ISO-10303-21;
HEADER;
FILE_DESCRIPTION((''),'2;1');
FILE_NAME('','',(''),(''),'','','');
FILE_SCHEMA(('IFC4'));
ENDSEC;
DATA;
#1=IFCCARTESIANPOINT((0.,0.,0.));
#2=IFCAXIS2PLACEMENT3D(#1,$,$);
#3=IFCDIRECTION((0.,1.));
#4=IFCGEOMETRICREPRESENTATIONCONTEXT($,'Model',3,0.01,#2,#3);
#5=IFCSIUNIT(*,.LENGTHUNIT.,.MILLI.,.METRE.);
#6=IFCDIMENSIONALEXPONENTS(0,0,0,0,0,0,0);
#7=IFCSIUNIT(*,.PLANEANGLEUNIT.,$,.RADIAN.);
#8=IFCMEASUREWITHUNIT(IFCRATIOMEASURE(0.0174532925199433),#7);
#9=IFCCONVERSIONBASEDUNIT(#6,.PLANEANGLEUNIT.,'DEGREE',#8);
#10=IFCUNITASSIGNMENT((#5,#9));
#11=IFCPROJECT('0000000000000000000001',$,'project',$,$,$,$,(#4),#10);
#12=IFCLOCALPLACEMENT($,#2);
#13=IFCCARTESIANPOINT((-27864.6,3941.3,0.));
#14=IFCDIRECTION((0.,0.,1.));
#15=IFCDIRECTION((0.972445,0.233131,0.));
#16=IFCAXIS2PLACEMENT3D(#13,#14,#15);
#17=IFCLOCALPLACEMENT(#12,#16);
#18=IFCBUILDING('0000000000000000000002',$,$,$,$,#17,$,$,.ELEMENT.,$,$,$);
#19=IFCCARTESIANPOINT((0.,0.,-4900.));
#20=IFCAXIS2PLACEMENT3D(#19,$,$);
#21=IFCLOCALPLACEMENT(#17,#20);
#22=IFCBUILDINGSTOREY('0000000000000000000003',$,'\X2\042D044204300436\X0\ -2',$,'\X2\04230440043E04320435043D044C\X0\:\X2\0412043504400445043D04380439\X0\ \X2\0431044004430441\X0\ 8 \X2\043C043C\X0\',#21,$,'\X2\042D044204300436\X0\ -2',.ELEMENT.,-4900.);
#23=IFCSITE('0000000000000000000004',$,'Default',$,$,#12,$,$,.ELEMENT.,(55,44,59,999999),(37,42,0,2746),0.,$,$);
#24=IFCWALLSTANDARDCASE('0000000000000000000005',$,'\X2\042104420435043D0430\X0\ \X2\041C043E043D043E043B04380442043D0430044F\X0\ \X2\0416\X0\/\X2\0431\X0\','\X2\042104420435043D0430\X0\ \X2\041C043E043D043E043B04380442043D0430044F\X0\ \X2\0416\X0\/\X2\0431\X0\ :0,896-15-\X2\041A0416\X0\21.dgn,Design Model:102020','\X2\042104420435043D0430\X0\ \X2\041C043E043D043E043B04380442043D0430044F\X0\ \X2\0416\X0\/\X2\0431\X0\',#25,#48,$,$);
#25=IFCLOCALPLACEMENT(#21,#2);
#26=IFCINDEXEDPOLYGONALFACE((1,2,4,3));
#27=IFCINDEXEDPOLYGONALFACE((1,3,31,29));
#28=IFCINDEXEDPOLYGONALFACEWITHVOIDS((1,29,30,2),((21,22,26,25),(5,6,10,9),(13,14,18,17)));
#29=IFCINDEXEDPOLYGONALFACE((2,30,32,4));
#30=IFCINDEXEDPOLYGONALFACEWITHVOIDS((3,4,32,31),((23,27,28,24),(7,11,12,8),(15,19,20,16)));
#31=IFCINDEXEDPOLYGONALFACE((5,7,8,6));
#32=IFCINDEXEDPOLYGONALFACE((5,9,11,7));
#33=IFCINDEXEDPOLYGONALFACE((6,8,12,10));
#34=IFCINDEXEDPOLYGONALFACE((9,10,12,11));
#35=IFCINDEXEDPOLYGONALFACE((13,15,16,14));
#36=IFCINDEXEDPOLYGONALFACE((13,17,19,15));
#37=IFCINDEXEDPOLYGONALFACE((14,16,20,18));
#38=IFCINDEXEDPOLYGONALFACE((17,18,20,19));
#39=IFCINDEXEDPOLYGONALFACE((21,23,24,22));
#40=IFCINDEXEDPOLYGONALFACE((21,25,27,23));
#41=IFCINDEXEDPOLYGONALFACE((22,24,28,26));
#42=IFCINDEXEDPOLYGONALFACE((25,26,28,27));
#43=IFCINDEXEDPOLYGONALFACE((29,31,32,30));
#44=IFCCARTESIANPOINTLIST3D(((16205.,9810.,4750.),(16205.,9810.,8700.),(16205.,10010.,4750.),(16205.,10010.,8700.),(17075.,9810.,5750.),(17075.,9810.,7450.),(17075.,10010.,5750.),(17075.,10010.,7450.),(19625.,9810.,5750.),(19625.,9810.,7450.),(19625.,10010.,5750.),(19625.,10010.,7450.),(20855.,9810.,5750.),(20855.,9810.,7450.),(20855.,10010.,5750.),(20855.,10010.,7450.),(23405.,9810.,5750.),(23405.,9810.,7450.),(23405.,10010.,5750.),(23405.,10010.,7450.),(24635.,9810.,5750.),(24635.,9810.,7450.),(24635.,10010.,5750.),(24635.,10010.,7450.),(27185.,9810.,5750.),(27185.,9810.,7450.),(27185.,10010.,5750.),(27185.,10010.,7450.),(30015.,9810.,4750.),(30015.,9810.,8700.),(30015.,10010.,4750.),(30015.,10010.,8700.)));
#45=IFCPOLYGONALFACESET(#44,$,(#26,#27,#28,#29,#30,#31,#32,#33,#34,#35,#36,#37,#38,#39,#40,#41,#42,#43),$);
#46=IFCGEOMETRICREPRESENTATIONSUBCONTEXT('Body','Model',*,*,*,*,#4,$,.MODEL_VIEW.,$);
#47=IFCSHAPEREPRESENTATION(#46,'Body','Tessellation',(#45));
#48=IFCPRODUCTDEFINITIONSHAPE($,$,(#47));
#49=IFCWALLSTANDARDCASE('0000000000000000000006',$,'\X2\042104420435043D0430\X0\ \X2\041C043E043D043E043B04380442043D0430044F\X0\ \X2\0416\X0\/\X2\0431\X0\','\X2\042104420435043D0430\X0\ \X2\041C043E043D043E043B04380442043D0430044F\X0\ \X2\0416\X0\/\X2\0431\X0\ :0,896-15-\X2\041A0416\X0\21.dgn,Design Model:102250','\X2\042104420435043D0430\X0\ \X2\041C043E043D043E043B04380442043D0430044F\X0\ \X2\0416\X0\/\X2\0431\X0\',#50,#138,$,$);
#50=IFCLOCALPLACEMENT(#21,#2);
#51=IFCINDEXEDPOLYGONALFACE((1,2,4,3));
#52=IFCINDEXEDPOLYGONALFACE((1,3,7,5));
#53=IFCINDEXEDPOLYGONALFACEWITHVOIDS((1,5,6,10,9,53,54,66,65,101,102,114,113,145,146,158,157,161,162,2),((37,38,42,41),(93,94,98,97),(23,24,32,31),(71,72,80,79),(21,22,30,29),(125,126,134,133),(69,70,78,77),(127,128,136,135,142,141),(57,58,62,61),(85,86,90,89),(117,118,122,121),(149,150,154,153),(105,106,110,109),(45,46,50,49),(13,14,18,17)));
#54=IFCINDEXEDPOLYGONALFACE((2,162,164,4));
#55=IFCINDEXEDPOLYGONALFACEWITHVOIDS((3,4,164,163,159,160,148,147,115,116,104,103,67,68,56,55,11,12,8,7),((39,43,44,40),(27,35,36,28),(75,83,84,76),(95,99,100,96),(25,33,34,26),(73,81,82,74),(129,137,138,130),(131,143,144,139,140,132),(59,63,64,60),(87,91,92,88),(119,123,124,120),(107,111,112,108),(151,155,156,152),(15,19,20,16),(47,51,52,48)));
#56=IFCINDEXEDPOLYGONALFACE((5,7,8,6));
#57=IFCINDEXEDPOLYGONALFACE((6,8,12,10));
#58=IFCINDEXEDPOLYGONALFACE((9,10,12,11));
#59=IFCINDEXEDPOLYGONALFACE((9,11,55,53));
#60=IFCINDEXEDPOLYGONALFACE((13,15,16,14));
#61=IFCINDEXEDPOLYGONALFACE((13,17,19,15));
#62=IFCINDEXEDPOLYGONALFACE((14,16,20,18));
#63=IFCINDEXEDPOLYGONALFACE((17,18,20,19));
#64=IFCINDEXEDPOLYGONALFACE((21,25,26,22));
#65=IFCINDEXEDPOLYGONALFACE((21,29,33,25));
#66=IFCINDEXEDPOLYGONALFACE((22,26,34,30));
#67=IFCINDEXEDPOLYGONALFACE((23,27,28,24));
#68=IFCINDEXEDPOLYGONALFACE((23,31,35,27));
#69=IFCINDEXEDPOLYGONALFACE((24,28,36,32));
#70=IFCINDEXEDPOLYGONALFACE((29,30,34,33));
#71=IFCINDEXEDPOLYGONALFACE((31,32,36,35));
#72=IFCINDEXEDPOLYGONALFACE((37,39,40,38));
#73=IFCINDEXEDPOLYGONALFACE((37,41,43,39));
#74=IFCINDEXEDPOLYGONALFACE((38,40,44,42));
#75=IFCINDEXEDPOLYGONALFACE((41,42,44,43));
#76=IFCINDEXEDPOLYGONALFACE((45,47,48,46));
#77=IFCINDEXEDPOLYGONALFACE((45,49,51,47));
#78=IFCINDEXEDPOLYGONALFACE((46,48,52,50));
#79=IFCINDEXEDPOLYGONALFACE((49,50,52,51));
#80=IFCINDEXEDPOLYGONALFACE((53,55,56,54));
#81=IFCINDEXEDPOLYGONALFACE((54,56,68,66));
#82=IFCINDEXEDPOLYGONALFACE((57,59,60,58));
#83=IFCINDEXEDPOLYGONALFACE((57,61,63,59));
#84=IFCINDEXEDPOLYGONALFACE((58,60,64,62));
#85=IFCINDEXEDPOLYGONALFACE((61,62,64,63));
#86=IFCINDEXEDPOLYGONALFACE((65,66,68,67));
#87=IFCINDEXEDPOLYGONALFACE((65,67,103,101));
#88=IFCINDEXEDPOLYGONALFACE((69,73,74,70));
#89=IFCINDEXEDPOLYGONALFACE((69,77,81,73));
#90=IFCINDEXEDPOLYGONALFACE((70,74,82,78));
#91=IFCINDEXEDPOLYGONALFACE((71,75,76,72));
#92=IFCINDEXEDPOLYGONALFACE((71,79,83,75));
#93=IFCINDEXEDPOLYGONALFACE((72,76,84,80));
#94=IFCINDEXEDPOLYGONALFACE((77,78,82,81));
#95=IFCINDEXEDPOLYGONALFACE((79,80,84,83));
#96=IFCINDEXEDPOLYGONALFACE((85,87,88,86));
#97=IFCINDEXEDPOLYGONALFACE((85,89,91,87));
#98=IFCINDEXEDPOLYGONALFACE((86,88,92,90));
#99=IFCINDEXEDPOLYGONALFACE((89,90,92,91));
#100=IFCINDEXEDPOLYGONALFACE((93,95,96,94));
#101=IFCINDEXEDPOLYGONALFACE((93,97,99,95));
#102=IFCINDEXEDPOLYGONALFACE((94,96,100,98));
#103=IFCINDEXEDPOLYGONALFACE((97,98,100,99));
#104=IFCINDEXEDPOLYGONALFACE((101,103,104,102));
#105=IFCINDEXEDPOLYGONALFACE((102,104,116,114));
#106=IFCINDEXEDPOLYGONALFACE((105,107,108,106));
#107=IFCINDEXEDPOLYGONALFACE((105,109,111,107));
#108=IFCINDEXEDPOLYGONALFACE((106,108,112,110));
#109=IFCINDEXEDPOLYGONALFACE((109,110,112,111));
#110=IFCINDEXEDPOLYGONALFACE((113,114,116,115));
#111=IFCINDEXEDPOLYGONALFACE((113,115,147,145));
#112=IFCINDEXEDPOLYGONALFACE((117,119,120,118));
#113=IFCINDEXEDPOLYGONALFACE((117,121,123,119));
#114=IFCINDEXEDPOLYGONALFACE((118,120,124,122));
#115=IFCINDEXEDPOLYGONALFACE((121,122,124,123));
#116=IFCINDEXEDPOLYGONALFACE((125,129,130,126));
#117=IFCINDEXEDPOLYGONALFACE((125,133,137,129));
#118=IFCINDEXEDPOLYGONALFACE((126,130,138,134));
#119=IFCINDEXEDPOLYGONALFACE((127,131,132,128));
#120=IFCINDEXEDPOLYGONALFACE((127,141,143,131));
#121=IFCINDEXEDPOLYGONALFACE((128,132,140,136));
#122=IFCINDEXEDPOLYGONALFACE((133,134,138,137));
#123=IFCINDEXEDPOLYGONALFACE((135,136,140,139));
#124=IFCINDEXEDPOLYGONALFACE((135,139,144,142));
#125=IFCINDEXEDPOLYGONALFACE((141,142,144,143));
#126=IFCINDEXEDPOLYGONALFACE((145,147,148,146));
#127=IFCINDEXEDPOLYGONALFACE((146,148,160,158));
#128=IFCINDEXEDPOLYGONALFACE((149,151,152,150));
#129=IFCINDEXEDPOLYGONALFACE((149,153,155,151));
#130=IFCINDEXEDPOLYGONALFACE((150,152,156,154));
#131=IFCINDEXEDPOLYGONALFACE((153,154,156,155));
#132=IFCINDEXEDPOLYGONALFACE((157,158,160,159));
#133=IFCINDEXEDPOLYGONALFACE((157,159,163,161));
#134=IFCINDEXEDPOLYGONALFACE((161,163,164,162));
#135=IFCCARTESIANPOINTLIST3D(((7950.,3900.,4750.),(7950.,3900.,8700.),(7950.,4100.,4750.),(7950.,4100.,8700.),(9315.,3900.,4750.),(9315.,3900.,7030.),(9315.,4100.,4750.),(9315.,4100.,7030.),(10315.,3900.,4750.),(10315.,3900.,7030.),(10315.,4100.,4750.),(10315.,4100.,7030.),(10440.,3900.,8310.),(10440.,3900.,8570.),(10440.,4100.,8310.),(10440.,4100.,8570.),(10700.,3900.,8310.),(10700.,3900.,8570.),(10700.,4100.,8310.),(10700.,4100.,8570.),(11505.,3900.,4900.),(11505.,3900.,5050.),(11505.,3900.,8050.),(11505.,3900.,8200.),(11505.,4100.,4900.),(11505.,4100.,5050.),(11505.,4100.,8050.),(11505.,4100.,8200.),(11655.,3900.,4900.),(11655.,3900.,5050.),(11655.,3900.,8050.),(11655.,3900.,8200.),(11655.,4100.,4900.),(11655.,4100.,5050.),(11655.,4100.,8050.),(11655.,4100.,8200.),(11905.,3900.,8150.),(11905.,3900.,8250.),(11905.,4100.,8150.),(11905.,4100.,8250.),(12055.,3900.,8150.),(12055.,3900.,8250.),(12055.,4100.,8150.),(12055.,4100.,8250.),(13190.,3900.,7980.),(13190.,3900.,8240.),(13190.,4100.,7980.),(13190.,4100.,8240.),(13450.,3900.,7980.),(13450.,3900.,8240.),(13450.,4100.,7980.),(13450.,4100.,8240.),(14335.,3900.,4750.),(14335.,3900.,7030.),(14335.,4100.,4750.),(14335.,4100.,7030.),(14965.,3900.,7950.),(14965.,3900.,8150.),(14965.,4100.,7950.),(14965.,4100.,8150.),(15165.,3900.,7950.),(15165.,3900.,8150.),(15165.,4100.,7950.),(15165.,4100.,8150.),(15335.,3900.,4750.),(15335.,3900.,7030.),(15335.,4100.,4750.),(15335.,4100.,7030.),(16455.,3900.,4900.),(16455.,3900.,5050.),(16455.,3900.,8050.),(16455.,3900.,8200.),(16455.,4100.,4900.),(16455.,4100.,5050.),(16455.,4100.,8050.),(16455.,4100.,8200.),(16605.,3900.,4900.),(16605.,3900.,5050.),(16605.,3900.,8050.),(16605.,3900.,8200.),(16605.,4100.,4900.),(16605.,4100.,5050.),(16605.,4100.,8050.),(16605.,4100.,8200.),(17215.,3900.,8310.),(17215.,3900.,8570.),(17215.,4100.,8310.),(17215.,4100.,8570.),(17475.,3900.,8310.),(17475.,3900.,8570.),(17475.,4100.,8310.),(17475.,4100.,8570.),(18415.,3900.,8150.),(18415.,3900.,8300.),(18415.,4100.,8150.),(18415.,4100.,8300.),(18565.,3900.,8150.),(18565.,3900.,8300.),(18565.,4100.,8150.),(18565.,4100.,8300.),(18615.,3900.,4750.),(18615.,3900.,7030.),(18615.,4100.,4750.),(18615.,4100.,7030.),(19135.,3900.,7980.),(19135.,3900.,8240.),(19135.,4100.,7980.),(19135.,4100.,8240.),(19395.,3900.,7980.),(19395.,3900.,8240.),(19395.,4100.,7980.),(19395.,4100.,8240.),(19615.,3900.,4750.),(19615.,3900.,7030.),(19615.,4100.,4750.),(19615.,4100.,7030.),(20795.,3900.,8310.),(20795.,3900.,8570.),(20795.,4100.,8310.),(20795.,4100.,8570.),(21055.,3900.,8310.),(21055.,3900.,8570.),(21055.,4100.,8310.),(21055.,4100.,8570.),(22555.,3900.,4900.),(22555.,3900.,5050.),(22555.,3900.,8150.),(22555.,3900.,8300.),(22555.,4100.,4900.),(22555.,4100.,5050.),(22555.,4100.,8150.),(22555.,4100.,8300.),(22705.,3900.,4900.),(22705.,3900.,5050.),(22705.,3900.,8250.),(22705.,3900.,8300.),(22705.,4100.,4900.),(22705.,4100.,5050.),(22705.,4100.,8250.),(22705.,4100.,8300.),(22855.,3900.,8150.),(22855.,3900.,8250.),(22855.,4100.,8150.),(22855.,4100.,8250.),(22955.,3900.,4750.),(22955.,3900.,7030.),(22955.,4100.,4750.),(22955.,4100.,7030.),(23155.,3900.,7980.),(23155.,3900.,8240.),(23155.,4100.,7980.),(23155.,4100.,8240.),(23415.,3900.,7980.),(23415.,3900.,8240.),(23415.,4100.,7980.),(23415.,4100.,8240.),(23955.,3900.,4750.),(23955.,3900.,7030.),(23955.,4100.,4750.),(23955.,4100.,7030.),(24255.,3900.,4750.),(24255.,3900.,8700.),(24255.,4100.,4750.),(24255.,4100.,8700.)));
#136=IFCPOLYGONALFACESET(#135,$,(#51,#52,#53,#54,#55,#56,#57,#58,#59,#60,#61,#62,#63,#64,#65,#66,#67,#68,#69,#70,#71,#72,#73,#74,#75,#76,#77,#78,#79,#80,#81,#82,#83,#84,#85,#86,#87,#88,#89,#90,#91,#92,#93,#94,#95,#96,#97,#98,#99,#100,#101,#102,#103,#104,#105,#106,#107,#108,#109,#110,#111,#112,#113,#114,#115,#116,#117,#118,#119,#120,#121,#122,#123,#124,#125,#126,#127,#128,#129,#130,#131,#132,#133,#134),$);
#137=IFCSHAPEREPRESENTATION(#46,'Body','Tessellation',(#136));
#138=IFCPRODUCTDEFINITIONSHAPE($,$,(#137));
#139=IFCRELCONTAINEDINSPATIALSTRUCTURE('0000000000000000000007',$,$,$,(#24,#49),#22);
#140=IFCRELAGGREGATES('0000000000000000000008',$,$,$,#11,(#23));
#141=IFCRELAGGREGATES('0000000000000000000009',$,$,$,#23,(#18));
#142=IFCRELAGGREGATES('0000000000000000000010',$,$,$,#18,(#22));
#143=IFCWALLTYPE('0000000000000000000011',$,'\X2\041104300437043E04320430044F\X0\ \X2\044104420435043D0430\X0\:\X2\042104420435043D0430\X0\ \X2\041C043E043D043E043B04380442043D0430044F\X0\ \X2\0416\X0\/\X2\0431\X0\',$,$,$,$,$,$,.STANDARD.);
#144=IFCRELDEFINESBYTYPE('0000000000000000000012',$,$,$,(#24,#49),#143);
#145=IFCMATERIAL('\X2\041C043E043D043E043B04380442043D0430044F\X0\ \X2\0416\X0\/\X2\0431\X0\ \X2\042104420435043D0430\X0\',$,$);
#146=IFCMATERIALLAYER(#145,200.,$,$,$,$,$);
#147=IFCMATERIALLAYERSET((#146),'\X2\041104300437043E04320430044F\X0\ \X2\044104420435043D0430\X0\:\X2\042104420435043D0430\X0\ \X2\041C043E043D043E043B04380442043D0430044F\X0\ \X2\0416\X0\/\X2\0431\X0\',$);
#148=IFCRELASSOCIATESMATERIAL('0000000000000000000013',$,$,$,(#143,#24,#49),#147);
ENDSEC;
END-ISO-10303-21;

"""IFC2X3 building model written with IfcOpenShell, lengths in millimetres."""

from ifc_helpers import new_model, entity, si_unit, converted_unit, direction, frame, frame_2d, origin, origin_2d_with_axis, place, context, subcontext, project, spatial, polyline, rectangle, outline, extrude, material, layer, layer_set, layer_usage, type_object, element, save


model = new_model("IFC2X3")

# Units and contexts
model_context = context("Model", 3, precision=0.01, world=origin(), true_north=direction((0.0, 1.0)))
body_context = subcontext(model_context, "Body", "Model", "MODEL_VIEW")
ifc_project = project(units=[si_unit("LENGTHUNIT", "METRE", prefix="MILLI"), converted_unit("PLANEANGLEUNIT", "DEGREE", entity("IfcRatioMeasure", 0.0174532925199433), si_unit("PLANEANGLEUNIT", "RADIAN"), dimensions=[0, 0, 0, 0, 0, 0, 0])], contexts=[model_context])

# Site, building, storey
site_placement = place(None, origin())
site = spatial("IfcSite", under=ifc_project, at=site_placement, Name="Default", CompositionType="ELEMENT", RefLatitude=(55, 44, 59, 999999), RefLongitude=(37, 42, 0, 2746), RefElevation=0.0)
building_placement = place(site_placement, frame((-27864.6, 3941.3, 0.0), z_axis=(0.0, 0.0, 1.0), x_axis=(0.972445, 0.233131, 0.0)))
building = spatial("IfcBuilding", under=site, at=building_placement, CompositionType="ELEMENT")
storey_placement = place(building_placement, frame((0.0, 0.0, -4900.0)))
storey = spatial("IfcBuildingStorey", under=building, at=storey_placement, Name="Этаж -2", ObjectType="Уровень:Верхний брус 8 мм", LongName="Этаж -2", CompositionType="ELEMENT", Elevation=-4900.0)

# Walls, openings
ifc_material = material(Name="Монолитная Ж/б Стена")
ifc_layer_1 = layer(ifc_material, 200.0)
ifc_layer_set_1 = layer_set([ifc_layer_1], Name="Базовая стена:Стена Монолитная Ж/б")
ifc_layer_usage_1 = layer_usage(ifc_layer_set_1, "AXIS2", "NEGATIVE", 100.0)
wall_type_1 = type_object("IfcWallType", Name="Базовая стена:Стена Монолитная Ж/б", PredefinedType="STANDARD", material=ifc_layer_set_1)
wall_1_placement = place(storey_placement, frame((16205.0, 9910.0, 4750.0)))
wall_1 = element("IfcWallStandardCase", 1, at=wall_1_placement, inside=storey, type_object=wall_type_1, material=ifc_layer_usage_1, Name="Стена Монолитная Ж/б", Description="Стена Монолитная Ж/б :0,896-15-КЖ21.dgn,Design Model:102020", ObjectType="Стена Монолитная Ж/б", context=body_context, shape_type="SweptSolid", body=[
    extrude(rectangle(XDim=13810.0, YDim=200.0, at=frame_2d((6905.0, 0.0), x_axis=(-1.0, 0.0))), origin(), (0.0, 0.0, 1.0), 3950.0),
])
placement_1 = place(wall_1_placement, origin())
element("IfcOpeningElement", 2, at=placement_1, cuts=wall_1, ObjectType="Opening", context=body_context, shape_type="SweptSolid", body=[
    extrude(rectangle(XDim=1700.0, YDim=2550.0, at=origin_2d_with_axis()), frame((2145.0, -100.0, 1850.0), z_axis=(0.0, 1.0, 0.0), x_axis=(0.0, 0.0, -1.0)), (0.0, 0.0, 1.0), 200.0),
])
element("IfcOpeningElement", 3, at=placement_1, cuts=wall_1, ObjectType="Opening", context=body_context, shape_type="SweptSolid", body=[
    extrude(rectangle(XDim=1700.0, YDim=2550.0, at=origin_2d_with_axis()), frame((5925.0, -100.0, 1850.0), z_axis=(0.0, 1.0, 0.0), x_axis=(0.0, 0.0, -1.0)), (0.0, 0.0, 1.0), 200.0),
])
element("IfcOpeningElement", 4, at=placement_1, cuts=wall_1, ObjectType="Opening", context=body_context, shape_type="SweptSolid", body=[
    extrude(rectangle(XDim=1700.0, YDim=2550.0, at=origin_2d_with_axis()), frame((9705.0, -100.0, 1850.0), z_axis=(0.0, 1.0, 0.0), x_axis=(0.0, 0.0, -1.0)), (0.0, 0.0, 1.0), 200.0),
])
wall_2_placement = place(storey_placement, frame((24255.0, 4000.0, 4750.0), z_axis=(0.0, 0.0, 1.0), x_axis=(-1.0, 0.0, 0.0)))
wall_2 = element("IfcWallStandardCase", 5, at=wall_2_placement, inside=storey, type_object=wall_type_1, material=ifc_layer_usage_1, Name="Стена Монолитная Ж/б", Description="Стена Монолитная Ж/б :0,896-15-КЖ21.dgn,Design Model:102250", ObjectType="Стена Монолитная Ж/б", context=body_context, shape_type="SweptSolid", body=[
    extrude(rectangle(XDim=16305.0, YDim=200.0, at=frame_2d((8152.5, 0.0), x_axis=(-1.0, 0.0))), origin(), (0.0, 0.0, 1.0), 3950.0),
])
placement_2 = place(wall_2_placement, origin())
element("IfcOpeningElement", 6, at=placement_2, cuts=wall_2, ObjectType="Opening", context=body_context, shape_type="SweptSolid", body=[
    extrude(rectangle(XDim=2280.0, YDim=1000.0, at=origin_2d_with_axis()), frame((14440.0, -100.0, 1140.0), z_axis=(0.0, 1.0, 0.0), x_axis=(0.0, 0.0, -1.0)), (0.0, 0.0, 1.0), 200.0),
])
element("IfcOpeningElement", 7, at=placement_2, cuts=wall_2, ObjectType="Opening", context=body_context, shape_type="SweptSolid", body=[
    extrude(rectangle(XDim=2280.0, YDim=1000.0, at=origin_2d_with_axis()), frame((9420.0, -100.0, 1140.0), z_axis=(0.0, 1.0, 0.0), x_axis=(0.0, 0.0, -1.0)), (0.0, 0.0, 1.0), 200.0),
])
element("IfcOpeningElement", 8, at=placement_2, cuts=wall_2, ObjectType="Opening", context=body_context, shape_type="SweptSolid", body=[
    extrude(rectangle(XDim=2280.0, YDim=1000.0, at=origin_2d_with_axis()), frame((5140.0, -100.0, 1140.0), z_axis=(0.0, 1.0, 0.0), x_axis=(0.0, 0.0, -1.0)), (0.0, 0.0, 1.0), 200.0),
])
element("IfcOpeningElement", 9, at=placement_2, cuts=wall_2, ObjectType="Opening", context=body_context, shape_type="SweptSolid", body=[
    extrude(rectangle(XDim=2280.0, YDim=1000.0, at=origin_2d_with_axis()), frame((800.0, -100.0, 1140.0), z_axis=(0.0, 1.0, 0.0), x_axis=(0.0, 0.0, -1.0)), (0.0, 0.0, 1.0), 200.0),
])
element("IfcOpeningElement", 10, at=placement_2, cuts=wall_2, ObjectType="Opening", context=body_context, shape_type="SweptSolid", body=[
    extrude(rectangle(XDim=200.0, YDim=200.0, at=origin_2d_with_axis()), frame((9190.0, -100.0, 3300.0), z_axis=(0.0, 1.0, 0.0), x_axis=(0.0, 0.0, -1.0)), (0.0, 0.0, 1.0), 200.0),
])
element("IfcOpeningElement", 11, at=placement_2, cuts=wall_2, ObjectType="Opening", context=body_context, shape_type="SweptSolid", body=[
    extrude(rectangle(XDim=150.0, YDim=150.0, at=origin_2d_with_axis()), frame((7725.0, -100.0, 225.0), z_axis=(0.0, 1.0, 0.0), x_axis=(0.0, 0.0, -1.0)), (0.0, 0.0, 1.0), 200.0),
])
element("IfcOpeningElement", 12, at=placement_2, cuts=wall_2, ObjectType="Opening", context=body_context, shape_type="SweptSolid", body=[
    extrude(rectangle(XDim=150.0, YDim=150.0, at=origin_2d_with_axis()), frame((7725.0, -100.0, 3375.0), z_axis=(0.0, 1.0, 0.0), x_axis=(0.0, 0.0, -1.0)), (0.0, 0.0, 1.0), 200.0),
])
element("IfcOpeningElement", 13, at=placement_2, cuts=wall_2, ObjectType="Opening", context=body_context, shape_type="SweptSolid", body=[
    extrude(rectangle(XDim=260.0, YDim=260.0, at=origin_2d_with_axis()), frame((6910.0, -100.0, 3690.0), z_axis=(0.0, 1.0, 0.0), x_axis=(0.0, 0.0, -1.0)), (0.0, 0.0, 1.0), 200.0),
])
element("IfcOpeningElement", 14, at=placement_2, cuts=wall_2, ObjectType="Opening", context=body_context, shape_type="SweptSolid", body=[
    extrude(rectangle(XDim=150.0, YDim=150.0, at=origin_2d_with_axis()), frame((5765.0, -100.0, 3475.0), z_axis=(0.0, 1.0, 0.0), x_axis=(0.0, 0.0, -1.0)), (0.0, 0.0, 1.0), 200.0),
])
element("IfcOpeningElement", 15, at=placement_2, cuts=wall_2, ObjectType="Opening", context=body_context, shape_type="SweptSolid", body=[
    extrude(rectangle(XDim=260.0, YDim=260.0, at=origin_2d_with_axis()), frame((4990.0, -100.0, 3360.0), z_axis=(0.0, 1.0, 0.0), x_axis=(0.0, 0.0, -1.0)), (0.0, 0.0, 1.0), 200.0),
])
element("IfcOpeningElement", 16, at=placement_2, cuts=wall_2, ObjectType="Opening", context=body_context, shape_type="SweptSolid", body=[
    extrude(rectangle(XDim=260.0, YDim=260.0, at=origin_2d_with_axis()), frame((3330.0, -100.0, 3690.0), z_axis=(0.0, 1.0, 0.0), x_axis=(0.0, 0.0, -1.0)), (0.0, 0.0, 1.0), 200.0),
])
element("IfcOpeningElement", 17, at=placement_2, cuts=wall_2, ObjectType="Opening", context=body_context, shape_type="SweptSolid", body=[
    extrude(rectangle(XDim=260.0, YDim=260.0, at=origin_2d_with_axis()), frame((970.0, -100.0, 3360.0), z_axis=(0.0, 1.0, 0.0), x_axis=(0.0, 0.0, -1.0)), (0.0, 0.0, 1.0), 200.0),
])
element("IfcOpeningElement", 18, at=placement_2, cuts=wall_2, ObjectType="Opening", context=body_context, shape_type="SweptSolid", body=[
    extrude(rectangle(XDim=150.0, YDim=150.0, at=origin_2d_with_axis()), frame((1625.0, -100.0, 225.0), z_axis=(0.0, 1.0, 0.0), x_axis=(0.0, 0.0, -1.0)), (0.0, 0.0, 1.0), 200.0),
])
element("IfcOpeningElement", 19, at=placement_2, cuts=wall_2, ObjectType="Opening", context=body_context, shape_type="SweptSolid", body=[
    extrude(rectangle(XDim=260.0, YDim=260.0, at=origin_2d_with_axis()), frame((13685.0, -100.0, 3690.0), z_axis=(0.0, 1.0, 0.0), x_axis=(0.0, 0.0, -1.0)), (0.0, 0.0, 1.0), 200.0),
])
element("IfcOpeningElement", 20, at=placement_2, cuts=wall_2, ObjectType="Opening", context=body_context, shape_type="SweptSolid", body=[
    extrude(rectangle(XDim=150.0, YDim=150.0, at=origin_2d_with_axis()), frame((12675.0, -100.0, 3375.0), z_axis=(0.0, 1.0, 0.0), x_axis=(0.0, 0.0, -1.0)), (0.0, 0.0, 1.0), 200.0),
])
element("IfcOpeningElement", 21, at=placement_2, cuts=wall_2, ObjectType="Opening", context=body_context, shape_type="SweptSolid", body=[
    extrude(rectangle(XDim=100.0, YDim=150.0, at=origin_2d_with_axis()), frame((12275.0, -100.0, 3450.0), z_axis=(0.0, 1.0, 0.0), x_axis=(0.0, 0.0, -1.0)), (0.0, 0.0, 1.0), 200.0),
])
element("IfcOpeningElement", 22, at=placement_2, cuts=wall_2, ObjectType="Opening", context=body_context, shape_type="SweptSolid", body=[
    extrude(rectangle(XDim=150.0, YDim=150.0, at=origin_2d_with_axis()), frame((12675.0, -100.0, 225.0), z_axis=(0.0, 1.0, 0.0), x_axis=(0.0, 0.0, -1.0)), (0.0, 0.0, 1.0), 200.0),
])
element("IfcOpeningElement", 23, at=placement_2, cuts=wall_2, ObjectType="Opening", context=body_context, shape_type="SweptSolid", body=[
    extrude(rectangle(XDim=260.0, YDim=260.0, at=origin_2d_with_axis()), frame((10935.0, -100.0, 3360.0), z_axis=(0.0, 1.0, 0.0), x_axis=(0.0, 0.0, -1.0)), (0.0, 0.0, 1.0), 200.0),
])
element("IfcOpeningElement", 24, at=placement_2, cuts=wall_2, ObjectType="Opening", context=body_context, shape_type="SweptSolid", body=[
    extrude(outline(polyline([(16.7, 0.0), (66.7, 0.0), (66.7, 150.0), (-83.3, 150.0), (-83.3, -150.0), (16.7, -150.0), (16.7, 0.0)])), frame((1550.0, -100.0, 3483.3), z_axis=(0.0, 1.0, 0.0), x_axis=(0.0, 0.0, 1.0)), (0.0, 0.0, 1.0), 200.0),
])

save(model, "model.ifc")
